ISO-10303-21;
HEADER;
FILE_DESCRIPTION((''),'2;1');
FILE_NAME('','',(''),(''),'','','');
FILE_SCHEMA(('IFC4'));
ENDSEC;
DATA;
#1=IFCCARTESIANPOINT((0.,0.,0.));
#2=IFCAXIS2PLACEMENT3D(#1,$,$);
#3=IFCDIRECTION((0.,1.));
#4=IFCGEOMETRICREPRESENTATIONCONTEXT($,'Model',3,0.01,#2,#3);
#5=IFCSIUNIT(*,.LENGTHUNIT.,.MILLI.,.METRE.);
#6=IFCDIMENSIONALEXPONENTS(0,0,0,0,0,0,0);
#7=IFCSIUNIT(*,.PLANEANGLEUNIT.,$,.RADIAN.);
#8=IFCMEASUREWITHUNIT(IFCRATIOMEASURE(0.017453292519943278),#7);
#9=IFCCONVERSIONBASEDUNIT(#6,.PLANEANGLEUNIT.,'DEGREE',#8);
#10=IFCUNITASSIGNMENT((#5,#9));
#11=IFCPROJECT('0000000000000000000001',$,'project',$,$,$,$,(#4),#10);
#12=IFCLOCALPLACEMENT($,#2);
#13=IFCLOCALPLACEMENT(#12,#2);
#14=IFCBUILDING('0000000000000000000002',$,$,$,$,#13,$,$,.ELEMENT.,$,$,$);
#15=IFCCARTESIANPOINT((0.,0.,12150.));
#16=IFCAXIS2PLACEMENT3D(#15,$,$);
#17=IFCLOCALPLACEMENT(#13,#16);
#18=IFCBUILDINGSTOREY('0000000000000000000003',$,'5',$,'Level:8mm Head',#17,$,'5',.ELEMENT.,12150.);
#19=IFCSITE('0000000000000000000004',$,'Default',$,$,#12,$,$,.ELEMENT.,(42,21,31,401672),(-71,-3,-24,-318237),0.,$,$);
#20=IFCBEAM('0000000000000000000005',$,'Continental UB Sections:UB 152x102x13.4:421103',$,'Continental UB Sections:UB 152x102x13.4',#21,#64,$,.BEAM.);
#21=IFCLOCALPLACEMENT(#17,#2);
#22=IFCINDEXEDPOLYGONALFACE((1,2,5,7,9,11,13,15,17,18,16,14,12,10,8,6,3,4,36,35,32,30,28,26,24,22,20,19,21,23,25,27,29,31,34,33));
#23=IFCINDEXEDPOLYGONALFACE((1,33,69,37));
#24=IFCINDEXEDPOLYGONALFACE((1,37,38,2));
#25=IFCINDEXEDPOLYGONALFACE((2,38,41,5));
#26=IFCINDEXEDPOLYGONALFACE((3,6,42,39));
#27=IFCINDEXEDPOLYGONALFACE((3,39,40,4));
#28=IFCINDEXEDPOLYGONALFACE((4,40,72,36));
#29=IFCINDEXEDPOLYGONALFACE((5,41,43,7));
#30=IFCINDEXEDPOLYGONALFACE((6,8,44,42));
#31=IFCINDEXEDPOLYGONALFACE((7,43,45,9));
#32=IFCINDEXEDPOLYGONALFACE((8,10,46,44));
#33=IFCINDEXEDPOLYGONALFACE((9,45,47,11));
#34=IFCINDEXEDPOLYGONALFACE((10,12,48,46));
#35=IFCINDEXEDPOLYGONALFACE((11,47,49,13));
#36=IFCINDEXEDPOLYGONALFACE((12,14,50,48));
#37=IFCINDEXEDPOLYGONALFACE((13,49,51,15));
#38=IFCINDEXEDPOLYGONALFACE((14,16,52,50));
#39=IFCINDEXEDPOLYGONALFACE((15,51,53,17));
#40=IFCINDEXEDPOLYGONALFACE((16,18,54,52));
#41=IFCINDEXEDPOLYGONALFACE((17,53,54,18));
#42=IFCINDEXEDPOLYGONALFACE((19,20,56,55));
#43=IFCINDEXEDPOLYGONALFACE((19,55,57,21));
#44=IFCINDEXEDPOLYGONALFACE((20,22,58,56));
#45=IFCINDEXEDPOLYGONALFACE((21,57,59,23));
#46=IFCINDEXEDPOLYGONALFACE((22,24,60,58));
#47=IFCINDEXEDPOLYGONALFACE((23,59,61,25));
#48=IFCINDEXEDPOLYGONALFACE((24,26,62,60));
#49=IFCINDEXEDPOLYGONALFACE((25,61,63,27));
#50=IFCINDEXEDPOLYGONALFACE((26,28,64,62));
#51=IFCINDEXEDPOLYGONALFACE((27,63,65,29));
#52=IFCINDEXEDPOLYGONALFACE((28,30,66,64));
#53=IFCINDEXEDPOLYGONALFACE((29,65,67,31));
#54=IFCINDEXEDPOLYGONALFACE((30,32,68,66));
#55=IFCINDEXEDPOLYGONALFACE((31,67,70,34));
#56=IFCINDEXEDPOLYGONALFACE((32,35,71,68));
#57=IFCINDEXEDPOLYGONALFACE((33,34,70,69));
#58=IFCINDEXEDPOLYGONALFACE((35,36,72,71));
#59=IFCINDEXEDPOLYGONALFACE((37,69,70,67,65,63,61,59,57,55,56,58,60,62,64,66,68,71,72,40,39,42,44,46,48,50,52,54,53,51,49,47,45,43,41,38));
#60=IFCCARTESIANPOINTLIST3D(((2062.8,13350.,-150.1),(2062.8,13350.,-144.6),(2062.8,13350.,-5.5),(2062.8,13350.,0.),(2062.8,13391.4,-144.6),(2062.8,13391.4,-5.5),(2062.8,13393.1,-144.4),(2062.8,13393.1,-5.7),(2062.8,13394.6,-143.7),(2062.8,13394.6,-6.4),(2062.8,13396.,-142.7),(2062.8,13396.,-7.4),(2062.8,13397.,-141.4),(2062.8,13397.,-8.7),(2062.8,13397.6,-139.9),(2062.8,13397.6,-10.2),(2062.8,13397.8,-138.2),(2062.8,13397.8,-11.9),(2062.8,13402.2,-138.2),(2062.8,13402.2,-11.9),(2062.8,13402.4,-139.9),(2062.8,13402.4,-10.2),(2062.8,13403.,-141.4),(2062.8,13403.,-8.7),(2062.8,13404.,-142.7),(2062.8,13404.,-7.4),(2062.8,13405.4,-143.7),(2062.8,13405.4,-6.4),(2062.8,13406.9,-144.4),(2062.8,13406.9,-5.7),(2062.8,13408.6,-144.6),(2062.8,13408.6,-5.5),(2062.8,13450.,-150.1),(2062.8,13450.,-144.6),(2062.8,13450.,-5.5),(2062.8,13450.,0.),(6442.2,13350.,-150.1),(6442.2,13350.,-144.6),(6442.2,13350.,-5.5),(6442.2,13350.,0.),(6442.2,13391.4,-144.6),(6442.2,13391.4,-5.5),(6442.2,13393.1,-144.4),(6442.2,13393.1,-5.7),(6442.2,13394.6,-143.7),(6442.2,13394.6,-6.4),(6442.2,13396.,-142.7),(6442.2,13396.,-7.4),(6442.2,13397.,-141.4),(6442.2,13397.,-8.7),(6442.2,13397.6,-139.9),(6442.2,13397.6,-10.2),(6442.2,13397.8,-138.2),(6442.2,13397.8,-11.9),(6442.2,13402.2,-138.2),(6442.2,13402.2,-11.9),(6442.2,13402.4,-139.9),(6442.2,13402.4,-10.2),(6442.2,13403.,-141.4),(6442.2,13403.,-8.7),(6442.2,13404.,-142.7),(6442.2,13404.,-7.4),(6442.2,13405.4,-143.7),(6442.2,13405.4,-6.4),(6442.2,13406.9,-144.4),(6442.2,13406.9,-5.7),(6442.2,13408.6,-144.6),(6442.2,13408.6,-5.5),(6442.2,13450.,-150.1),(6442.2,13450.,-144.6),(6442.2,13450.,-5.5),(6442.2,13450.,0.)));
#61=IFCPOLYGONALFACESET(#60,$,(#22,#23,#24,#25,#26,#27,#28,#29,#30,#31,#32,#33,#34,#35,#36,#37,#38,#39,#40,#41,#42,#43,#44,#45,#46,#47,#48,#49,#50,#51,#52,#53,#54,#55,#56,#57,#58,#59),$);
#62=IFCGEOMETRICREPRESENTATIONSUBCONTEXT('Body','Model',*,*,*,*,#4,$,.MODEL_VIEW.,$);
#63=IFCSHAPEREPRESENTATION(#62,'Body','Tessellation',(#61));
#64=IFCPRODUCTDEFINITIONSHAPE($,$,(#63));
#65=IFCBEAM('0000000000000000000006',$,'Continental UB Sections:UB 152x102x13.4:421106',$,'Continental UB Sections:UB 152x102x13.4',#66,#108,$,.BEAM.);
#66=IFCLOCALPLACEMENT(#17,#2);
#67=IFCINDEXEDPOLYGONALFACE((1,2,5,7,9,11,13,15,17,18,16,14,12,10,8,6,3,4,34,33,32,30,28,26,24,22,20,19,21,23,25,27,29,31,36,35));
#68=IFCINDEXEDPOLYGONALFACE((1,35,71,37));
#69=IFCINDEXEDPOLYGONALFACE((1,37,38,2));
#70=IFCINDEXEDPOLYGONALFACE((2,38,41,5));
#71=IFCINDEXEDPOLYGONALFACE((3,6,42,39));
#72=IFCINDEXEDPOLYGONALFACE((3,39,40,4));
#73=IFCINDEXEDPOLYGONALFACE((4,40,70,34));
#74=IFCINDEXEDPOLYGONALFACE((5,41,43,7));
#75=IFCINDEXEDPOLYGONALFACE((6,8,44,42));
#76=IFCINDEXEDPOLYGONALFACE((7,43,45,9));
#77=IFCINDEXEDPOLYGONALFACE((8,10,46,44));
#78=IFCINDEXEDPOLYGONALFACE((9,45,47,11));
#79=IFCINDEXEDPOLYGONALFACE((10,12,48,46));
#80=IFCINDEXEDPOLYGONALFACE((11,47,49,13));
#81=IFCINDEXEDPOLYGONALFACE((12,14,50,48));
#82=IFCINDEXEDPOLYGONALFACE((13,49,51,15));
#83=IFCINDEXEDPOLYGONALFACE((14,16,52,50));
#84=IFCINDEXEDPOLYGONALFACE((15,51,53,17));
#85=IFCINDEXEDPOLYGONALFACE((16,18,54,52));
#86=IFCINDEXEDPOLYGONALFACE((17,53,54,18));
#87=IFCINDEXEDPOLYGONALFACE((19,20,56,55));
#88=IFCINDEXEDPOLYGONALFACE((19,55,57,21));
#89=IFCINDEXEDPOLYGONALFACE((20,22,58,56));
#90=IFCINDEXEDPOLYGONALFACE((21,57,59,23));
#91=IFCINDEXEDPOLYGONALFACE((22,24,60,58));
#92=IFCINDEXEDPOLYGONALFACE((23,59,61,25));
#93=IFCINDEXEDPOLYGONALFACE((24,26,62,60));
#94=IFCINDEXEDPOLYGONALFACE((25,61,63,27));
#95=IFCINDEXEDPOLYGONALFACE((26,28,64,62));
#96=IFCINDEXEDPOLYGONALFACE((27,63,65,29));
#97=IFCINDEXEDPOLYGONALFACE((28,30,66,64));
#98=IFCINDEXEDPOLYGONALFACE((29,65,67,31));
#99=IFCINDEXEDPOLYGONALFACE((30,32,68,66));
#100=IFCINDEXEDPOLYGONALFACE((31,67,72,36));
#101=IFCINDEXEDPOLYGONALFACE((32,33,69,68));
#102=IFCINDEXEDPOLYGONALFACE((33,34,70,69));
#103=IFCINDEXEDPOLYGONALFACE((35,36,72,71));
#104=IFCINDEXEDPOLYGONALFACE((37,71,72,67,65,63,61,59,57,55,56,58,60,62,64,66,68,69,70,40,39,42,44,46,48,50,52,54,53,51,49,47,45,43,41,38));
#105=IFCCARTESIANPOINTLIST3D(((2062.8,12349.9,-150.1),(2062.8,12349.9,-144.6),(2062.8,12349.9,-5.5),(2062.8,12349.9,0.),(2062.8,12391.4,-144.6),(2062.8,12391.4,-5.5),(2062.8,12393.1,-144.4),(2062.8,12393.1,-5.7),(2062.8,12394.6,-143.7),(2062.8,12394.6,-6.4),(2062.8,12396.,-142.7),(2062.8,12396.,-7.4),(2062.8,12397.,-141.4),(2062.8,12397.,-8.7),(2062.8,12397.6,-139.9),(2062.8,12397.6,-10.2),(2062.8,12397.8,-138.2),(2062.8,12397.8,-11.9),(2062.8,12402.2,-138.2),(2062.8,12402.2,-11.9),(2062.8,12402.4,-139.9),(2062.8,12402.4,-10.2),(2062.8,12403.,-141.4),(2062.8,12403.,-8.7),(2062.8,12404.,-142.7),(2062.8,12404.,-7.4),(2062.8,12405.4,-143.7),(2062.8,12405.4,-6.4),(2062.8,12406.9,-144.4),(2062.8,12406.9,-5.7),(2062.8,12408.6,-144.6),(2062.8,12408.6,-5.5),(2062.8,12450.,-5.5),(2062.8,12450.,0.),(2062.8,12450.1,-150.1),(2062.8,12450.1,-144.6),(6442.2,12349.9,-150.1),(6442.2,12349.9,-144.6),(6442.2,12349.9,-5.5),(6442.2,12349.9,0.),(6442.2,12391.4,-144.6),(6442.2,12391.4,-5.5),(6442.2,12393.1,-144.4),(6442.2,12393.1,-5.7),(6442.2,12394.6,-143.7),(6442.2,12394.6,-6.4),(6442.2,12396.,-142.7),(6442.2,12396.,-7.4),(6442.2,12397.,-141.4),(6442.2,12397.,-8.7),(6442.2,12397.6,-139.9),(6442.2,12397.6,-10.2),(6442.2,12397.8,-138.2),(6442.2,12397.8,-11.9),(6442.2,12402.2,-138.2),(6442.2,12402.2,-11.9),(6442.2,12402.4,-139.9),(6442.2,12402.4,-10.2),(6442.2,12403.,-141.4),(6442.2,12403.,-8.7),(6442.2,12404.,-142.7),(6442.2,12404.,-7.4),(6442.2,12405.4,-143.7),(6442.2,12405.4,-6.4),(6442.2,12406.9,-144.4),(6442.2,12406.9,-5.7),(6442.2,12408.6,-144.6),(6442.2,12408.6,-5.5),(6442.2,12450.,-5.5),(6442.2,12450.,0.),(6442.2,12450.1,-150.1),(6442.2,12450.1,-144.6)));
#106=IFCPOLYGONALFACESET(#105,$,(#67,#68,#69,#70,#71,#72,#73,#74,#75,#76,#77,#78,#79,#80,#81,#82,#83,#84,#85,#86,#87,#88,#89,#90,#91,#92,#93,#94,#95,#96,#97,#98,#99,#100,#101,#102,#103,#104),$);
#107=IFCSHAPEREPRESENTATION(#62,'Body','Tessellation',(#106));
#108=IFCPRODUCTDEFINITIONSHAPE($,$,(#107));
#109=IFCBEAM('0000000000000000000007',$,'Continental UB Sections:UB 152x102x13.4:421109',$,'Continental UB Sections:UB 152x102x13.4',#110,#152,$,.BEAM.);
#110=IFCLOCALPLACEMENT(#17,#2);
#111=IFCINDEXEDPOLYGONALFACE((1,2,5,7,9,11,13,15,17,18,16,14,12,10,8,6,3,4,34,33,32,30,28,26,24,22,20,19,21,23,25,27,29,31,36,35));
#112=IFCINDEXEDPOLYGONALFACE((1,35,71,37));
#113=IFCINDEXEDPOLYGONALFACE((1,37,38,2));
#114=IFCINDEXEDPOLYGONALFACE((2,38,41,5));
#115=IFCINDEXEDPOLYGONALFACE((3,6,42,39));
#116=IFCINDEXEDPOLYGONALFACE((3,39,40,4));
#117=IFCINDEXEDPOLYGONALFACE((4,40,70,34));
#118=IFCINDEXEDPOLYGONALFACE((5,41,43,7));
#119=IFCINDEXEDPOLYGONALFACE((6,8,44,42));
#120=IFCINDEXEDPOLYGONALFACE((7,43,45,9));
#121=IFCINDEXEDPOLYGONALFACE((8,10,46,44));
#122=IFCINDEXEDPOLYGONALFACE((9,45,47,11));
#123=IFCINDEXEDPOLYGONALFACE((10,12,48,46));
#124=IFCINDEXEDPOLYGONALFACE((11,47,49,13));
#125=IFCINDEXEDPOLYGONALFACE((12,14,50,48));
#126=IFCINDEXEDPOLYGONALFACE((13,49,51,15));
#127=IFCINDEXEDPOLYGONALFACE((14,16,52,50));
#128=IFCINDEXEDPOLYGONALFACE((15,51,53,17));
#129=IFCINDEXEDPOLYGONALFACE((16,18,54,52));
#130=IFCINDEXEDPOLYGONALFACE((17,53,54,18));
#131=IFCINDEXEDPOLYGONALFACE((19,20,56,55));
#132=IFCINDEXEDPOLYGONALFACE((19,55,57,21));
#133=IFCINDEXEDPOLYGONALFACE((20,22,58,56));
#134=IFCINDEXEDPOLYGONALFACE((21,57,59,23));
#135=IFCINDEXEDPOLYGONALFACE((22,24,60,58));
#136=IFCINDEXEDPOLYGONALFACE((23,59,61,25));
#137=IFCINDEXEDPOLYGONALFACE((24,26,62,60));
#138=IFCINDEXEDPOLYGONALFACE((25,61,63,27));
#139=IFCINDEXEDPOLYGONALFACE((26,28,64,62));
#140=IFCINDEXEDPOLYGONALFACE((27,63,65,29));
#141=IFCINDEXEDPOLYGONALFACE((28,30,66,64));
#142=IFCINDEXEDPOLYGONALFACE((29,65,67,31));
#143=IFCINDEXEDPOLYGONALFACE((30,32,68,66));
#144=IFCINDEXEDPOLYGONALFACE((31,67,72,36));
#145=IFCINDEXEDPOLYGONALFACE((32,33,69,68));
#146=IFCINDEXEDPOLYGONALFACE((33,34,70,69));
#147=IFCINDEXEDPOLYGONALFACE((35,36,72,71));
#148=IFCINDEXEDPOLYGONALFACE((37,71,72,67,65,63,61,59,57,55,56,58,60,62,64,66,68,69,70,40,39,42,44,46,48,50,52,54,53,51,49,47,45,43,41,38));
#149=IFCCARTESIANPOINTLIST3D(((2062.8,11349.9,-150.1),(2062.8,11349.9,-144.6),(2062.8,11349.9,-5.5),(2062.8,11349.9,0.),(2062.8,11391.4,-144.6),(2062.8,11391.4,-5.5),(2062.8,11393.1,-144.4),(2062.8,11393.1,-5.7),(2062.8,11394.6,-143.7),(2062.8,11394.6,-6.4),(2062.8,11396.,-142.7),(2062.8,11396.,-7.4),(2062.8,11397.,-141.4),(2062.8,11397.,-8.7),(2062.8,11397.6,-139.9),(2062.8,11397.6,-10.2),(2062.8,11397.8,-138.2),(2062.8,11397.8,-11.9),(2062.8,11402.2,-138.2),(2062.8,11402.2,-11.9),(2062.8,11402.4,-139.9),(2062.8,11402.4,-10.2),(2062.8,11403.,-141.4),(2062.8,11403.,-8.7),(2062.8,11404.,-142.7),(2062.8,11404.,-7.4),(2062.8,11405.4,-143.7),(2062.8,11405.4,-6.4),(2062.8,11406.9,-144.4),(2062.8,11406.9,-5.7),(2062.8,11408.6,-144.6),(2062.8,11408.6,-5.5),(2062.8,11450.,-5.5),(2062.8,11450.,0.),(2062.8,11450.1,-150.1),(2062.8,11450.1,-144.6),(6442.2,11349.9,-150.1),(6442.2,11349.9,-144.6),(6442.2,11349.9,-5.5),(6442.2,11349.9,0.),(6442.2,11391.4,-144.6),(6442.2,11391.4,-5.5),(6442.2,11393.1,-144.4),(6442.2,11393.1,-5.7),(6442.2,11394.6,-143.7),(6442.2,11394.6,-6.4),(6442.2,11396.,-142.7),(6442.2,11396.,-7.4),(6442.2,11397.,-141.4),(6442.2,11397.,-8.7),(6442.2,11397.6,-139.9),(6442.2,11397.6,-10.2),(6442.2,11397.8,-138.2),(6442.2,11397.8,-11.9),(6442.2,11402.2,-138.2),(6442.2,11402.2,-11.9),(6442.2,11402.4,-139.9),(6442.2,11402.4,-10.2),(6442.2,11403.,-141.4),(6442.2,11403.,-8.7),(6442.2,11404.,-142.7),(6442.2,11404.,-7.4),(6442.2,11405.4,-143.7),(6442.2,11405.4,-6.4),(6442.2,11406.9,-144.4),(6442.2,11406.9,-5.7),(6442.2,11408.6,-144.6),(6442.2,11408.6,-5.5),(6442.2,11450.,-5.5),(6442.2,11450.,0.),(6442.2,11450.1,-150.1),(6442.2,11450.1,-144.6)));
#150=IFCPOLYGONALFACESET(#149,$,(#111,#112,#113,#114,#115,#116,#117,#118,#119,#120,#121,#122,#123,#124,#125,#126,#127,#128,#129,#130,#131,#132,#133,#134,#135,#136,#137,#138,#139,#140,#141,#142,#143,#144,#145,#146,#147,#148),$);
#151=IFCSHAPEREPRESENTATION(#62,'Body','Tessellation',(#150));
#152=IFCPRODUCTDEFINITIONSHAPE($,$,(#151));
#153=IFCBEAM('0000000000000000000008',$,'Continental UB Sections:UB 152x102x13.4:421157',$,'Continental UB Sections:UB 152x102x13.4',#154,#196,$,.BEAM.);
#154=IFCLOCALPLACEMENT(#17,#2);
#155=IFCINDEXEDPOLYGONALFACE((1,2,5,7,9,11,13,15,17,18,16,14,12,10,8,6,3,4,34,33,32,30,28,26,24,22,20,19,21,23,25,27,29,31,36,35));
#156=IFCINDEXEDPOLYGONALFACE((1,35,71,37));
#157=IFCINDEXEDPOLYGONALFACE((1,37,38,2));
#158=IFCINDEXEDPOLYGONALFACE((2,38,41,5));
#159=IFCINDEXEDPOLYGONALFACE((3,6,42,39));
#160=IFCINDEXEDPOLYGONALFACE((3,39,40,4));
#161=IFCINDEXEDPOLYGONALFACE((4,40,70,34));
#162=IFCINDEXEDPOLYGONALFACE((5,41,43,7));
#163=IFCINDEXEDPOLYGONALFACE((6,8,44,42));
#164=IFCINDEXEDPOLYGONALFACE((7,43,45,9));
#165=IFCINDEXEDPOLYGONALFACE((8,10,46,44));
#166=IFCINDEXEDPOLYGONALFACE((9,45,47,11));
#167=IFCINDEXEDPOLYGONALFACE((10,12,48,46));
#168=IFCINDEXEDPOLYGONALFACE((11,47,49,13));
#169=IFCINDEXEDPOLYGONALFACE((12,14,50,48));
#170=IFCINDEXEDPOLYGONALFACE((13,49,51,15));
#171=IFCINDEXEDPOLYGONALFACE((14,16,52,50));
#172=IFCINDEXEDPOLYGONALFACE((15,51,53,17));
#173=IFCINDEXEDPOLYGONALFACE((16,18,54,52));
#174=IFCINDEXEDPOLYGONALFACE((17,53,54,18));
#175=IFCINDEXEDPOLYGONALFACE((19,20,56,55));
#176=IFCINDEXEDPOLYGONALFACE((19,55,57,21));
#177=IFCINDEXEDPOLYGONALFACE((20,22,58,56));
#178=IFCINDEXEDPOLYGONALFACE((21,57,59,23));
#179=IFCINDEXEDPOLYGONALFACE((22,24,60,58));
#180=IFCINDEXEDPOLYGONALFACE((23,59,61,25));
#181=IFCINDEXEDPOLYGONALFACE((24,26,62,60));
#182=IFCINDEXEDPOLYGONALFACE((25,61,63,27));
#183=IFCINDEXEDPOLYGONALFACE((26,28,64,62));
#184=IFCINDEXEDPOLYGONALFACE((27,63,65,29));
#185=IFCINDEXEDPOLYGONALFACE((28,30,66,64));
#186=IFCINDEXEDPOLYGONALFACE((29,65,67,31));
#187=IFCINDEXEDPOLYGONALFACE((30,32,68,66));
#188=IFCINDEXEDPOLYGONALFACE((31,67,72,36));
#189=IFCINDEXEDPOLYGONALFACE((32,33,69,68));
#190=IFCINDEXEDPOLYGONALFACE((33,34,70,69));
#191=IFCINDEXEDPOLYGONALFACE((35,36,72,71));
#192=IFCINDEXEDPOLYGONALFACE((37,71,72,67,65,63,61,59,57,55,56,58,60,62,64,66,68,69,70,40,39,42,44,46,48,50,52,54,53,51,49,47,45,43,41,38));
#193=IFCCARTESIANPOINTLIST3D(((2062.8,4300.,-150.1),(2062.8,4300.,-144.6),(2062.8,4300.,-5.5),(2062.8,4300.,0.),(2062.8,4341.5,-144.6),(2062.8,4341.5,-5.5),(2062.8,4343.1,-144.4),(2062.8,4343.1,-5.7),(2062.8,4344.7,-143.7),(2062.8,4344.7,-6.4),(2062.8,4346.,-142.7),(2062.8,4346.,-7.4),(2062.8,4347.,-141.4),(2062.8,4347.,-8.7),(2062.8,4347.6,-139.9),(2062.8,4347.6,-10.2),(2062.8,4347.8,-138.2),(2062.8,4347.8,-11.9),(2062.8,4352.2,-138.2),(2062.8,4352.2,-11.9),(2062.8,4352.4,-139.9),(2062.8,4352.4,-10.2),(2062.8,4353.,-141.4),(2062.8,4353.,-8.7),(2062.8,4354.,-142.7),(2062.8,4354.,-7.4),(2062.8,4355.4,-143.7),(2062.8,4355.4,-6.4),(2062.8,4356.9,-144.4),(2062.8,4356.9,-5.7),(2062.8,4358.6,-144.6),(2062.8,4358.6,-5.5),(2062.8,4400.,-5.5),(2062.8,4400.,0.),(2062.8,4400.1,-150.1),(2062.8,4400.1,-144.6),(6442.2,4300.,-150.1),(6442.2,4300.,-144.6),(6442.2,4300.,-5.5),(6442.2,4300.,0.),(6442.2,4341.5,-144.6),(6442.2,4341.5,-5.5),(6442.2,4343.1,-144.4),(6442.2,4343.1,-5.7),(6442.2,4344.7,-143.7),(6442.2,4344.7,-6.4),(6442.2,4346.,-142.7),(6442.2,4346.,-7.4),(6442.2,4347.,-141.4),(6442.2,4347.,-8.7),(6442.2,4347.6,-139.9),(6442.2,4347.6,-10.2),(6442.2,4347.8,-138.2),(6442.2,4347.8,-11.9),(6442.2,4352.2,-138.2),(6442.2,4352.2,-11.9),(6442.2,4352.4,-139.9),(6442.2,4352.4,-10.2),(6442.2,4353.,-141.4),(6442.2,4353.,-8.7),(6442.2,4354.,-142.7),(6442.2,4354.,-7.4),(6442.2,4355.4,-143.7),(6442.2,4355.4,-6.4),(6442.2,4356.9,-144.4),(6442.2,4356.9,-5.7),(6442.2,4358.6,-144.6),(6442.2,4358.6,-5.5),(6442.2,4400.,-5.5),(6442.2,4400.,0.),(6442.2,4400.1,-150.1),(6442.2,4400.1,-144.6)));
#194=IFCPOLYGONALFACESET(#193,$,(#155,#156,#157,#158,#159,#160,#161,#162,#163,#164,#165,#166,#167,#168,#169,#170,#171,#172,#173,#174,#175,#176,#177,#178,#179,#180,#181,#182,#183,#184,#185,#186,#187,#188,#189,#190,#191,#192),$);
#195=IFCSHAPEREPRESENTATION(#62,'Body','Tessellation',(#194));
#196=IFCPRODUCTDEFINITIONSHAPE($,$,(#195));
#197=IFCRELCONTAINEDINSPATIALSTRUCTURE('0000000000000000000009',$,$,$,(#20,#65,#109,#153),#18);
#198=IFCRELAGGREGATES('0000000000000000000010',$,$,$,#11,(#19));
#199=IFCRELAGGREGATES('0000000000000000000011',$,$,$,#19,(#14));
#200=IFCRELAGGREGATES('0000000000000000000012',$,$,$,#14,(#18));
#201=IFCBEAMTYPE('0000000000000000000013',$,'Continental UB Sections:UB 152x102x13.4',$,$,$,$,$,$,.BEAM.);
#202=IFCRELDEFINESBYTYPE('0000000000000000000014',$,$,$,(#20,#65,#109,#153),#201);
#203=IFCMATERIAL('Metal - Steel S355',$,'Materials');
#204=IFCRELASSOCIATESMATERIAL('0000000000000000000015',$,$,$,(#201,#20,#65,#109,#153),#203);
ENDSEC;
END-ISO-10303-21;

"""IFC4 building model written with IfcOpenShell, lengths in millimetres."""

from ifc_helpers import new_model, entity, si_unit, converted_unit, direction, frame, origin, place, context, subcontext, project, spatial, line, arc, indexed_curve, outline, extrude, source, transform, mapped, material, type_object, type_shapes, element, save


model = new_model("IFC4")

# Units and contexts
model_context = context("Model", 3, precision=0.01, world=origin(), true_north=direction((0.0, 1.0)))
body_context = subcontext(model_context, "Body", "Model", "MODEL_VIEW")
ifc_project = project(units=[si_unit("LENGTHUNIT", "METRE", prefix="MILLI"), converted_unit("PLANEANGLEUNIT", "DEGREE", entity("IfcRatioMeasure", 0.017453292519943278), si_unit("PLANEANGLEUNIT", "RADIAN"), dimensions=[0, 0, 0, 0, 0, 0, 0])], contexts=[model_context])

# Site, building, storey
site_placement = place(None, origin())
site = spatial("IfcSite", under=ifc_project, at=site_placement, Name="Default", CompositionType="ELEMENT", RefLatitude=(42, 21, 31, 401672), RefLongitude=(-71, -3, -24, -318237), RefElevation=0.0)
building_placement = place(site_placement, origin())
building = spatial("IfcBuilding", under=site, at=building_placement, CompositionType="ELEMENT")
storey_placement = place(building_placement, frame((0.0, 0.0, 12150.0)))
storey = spatial("IfcBuildingStorey", under=building, at=storey_placement, Name="5", ObjectType="Level:8mm Head", LongName="5", CompositionType="ELEMENT", Elevation=12150.0)

# Beams
ifc_material = material(Name="Metal - Steel S355", Category="Materials")
beam_type_1 = type_object("IfcBeamType", Name="Continental UB Sections:UB 152x102x13.4", PredefinedType="BEAM", material=ifc_material)
shared_shape_1 = source(origin(), body_context, "Body", "SweptSolid", [
    extrude(outline(indexed_curve([(-75.0, -50.1), (-69.6, -50.1), (-69.6, -8.5), (-67.7, -4.0), (-63.2, -2.1), (63.1, -2.1), (67.7, -4.0), (69.5, -8.5), (69.5, -50.1), (75.1, -50.1), (75.1, 50.1), (69.5, 50.1), (69.5, 8.6), (67.7, 4.0), (63.1, 2.2), (-63.2, 2.2), (-67.7, 4.0), (-69.6, 8.6), (-69.6, 50.0), (-75.0, 50.0)], segments=[line(1, 2, 3), arc(3, 4, 5), line(5, 6), arc(6, 7, 8), line(8, 9, 10, 11, 12, 13), arc(13, 14, 15), line(15, 16), arc(16, 17, 18), line(18, 19, 20, 1)], self_intersect=False)), frame((-2189.7, 0.0, 0.0), z_axis=(1.0, 0.0, 0.0), x_axis=(0.0, 0.0, -1.0)), (0.0, 0.0, 1.0), 4379.4),
])
type_shapes(beam_type_1, [shared_shape_1])
for number, where, name in (
    (1, (4252.5, 13400.0, -75.1), "Continental UB Sections:UB 152x102x13.4:421103"),
    (2, (4252.5, 12400.0, -75.1), "Continental UB Sections:UB 152x102x13.4:421106"),
    (3, (4252.5, 11400.0, -75.1), "Continental UB Sections:UB 152x102x13.4:421109"),
    (4, (4252.5, 4350.0, -75.1), "Continental UB Sections:UB 152x102x13.4:421157"),
):
    element("IfcBeam", number, at=place(storey_placement, frame(where)), inside=storey, type_object=beam_type_1, material=ifc_material, Name=name, ObjectType="Continental UB Sections:UB 152x102x13.4", PredefinedType="BEAM", context=body_context, shape_type="MappedRepresentation", body=[
        mapped(shared_shape_1, transform((0.0, 0.0, 0.0), scale=1.0)),
    ])

save(model, "model.ifc")
